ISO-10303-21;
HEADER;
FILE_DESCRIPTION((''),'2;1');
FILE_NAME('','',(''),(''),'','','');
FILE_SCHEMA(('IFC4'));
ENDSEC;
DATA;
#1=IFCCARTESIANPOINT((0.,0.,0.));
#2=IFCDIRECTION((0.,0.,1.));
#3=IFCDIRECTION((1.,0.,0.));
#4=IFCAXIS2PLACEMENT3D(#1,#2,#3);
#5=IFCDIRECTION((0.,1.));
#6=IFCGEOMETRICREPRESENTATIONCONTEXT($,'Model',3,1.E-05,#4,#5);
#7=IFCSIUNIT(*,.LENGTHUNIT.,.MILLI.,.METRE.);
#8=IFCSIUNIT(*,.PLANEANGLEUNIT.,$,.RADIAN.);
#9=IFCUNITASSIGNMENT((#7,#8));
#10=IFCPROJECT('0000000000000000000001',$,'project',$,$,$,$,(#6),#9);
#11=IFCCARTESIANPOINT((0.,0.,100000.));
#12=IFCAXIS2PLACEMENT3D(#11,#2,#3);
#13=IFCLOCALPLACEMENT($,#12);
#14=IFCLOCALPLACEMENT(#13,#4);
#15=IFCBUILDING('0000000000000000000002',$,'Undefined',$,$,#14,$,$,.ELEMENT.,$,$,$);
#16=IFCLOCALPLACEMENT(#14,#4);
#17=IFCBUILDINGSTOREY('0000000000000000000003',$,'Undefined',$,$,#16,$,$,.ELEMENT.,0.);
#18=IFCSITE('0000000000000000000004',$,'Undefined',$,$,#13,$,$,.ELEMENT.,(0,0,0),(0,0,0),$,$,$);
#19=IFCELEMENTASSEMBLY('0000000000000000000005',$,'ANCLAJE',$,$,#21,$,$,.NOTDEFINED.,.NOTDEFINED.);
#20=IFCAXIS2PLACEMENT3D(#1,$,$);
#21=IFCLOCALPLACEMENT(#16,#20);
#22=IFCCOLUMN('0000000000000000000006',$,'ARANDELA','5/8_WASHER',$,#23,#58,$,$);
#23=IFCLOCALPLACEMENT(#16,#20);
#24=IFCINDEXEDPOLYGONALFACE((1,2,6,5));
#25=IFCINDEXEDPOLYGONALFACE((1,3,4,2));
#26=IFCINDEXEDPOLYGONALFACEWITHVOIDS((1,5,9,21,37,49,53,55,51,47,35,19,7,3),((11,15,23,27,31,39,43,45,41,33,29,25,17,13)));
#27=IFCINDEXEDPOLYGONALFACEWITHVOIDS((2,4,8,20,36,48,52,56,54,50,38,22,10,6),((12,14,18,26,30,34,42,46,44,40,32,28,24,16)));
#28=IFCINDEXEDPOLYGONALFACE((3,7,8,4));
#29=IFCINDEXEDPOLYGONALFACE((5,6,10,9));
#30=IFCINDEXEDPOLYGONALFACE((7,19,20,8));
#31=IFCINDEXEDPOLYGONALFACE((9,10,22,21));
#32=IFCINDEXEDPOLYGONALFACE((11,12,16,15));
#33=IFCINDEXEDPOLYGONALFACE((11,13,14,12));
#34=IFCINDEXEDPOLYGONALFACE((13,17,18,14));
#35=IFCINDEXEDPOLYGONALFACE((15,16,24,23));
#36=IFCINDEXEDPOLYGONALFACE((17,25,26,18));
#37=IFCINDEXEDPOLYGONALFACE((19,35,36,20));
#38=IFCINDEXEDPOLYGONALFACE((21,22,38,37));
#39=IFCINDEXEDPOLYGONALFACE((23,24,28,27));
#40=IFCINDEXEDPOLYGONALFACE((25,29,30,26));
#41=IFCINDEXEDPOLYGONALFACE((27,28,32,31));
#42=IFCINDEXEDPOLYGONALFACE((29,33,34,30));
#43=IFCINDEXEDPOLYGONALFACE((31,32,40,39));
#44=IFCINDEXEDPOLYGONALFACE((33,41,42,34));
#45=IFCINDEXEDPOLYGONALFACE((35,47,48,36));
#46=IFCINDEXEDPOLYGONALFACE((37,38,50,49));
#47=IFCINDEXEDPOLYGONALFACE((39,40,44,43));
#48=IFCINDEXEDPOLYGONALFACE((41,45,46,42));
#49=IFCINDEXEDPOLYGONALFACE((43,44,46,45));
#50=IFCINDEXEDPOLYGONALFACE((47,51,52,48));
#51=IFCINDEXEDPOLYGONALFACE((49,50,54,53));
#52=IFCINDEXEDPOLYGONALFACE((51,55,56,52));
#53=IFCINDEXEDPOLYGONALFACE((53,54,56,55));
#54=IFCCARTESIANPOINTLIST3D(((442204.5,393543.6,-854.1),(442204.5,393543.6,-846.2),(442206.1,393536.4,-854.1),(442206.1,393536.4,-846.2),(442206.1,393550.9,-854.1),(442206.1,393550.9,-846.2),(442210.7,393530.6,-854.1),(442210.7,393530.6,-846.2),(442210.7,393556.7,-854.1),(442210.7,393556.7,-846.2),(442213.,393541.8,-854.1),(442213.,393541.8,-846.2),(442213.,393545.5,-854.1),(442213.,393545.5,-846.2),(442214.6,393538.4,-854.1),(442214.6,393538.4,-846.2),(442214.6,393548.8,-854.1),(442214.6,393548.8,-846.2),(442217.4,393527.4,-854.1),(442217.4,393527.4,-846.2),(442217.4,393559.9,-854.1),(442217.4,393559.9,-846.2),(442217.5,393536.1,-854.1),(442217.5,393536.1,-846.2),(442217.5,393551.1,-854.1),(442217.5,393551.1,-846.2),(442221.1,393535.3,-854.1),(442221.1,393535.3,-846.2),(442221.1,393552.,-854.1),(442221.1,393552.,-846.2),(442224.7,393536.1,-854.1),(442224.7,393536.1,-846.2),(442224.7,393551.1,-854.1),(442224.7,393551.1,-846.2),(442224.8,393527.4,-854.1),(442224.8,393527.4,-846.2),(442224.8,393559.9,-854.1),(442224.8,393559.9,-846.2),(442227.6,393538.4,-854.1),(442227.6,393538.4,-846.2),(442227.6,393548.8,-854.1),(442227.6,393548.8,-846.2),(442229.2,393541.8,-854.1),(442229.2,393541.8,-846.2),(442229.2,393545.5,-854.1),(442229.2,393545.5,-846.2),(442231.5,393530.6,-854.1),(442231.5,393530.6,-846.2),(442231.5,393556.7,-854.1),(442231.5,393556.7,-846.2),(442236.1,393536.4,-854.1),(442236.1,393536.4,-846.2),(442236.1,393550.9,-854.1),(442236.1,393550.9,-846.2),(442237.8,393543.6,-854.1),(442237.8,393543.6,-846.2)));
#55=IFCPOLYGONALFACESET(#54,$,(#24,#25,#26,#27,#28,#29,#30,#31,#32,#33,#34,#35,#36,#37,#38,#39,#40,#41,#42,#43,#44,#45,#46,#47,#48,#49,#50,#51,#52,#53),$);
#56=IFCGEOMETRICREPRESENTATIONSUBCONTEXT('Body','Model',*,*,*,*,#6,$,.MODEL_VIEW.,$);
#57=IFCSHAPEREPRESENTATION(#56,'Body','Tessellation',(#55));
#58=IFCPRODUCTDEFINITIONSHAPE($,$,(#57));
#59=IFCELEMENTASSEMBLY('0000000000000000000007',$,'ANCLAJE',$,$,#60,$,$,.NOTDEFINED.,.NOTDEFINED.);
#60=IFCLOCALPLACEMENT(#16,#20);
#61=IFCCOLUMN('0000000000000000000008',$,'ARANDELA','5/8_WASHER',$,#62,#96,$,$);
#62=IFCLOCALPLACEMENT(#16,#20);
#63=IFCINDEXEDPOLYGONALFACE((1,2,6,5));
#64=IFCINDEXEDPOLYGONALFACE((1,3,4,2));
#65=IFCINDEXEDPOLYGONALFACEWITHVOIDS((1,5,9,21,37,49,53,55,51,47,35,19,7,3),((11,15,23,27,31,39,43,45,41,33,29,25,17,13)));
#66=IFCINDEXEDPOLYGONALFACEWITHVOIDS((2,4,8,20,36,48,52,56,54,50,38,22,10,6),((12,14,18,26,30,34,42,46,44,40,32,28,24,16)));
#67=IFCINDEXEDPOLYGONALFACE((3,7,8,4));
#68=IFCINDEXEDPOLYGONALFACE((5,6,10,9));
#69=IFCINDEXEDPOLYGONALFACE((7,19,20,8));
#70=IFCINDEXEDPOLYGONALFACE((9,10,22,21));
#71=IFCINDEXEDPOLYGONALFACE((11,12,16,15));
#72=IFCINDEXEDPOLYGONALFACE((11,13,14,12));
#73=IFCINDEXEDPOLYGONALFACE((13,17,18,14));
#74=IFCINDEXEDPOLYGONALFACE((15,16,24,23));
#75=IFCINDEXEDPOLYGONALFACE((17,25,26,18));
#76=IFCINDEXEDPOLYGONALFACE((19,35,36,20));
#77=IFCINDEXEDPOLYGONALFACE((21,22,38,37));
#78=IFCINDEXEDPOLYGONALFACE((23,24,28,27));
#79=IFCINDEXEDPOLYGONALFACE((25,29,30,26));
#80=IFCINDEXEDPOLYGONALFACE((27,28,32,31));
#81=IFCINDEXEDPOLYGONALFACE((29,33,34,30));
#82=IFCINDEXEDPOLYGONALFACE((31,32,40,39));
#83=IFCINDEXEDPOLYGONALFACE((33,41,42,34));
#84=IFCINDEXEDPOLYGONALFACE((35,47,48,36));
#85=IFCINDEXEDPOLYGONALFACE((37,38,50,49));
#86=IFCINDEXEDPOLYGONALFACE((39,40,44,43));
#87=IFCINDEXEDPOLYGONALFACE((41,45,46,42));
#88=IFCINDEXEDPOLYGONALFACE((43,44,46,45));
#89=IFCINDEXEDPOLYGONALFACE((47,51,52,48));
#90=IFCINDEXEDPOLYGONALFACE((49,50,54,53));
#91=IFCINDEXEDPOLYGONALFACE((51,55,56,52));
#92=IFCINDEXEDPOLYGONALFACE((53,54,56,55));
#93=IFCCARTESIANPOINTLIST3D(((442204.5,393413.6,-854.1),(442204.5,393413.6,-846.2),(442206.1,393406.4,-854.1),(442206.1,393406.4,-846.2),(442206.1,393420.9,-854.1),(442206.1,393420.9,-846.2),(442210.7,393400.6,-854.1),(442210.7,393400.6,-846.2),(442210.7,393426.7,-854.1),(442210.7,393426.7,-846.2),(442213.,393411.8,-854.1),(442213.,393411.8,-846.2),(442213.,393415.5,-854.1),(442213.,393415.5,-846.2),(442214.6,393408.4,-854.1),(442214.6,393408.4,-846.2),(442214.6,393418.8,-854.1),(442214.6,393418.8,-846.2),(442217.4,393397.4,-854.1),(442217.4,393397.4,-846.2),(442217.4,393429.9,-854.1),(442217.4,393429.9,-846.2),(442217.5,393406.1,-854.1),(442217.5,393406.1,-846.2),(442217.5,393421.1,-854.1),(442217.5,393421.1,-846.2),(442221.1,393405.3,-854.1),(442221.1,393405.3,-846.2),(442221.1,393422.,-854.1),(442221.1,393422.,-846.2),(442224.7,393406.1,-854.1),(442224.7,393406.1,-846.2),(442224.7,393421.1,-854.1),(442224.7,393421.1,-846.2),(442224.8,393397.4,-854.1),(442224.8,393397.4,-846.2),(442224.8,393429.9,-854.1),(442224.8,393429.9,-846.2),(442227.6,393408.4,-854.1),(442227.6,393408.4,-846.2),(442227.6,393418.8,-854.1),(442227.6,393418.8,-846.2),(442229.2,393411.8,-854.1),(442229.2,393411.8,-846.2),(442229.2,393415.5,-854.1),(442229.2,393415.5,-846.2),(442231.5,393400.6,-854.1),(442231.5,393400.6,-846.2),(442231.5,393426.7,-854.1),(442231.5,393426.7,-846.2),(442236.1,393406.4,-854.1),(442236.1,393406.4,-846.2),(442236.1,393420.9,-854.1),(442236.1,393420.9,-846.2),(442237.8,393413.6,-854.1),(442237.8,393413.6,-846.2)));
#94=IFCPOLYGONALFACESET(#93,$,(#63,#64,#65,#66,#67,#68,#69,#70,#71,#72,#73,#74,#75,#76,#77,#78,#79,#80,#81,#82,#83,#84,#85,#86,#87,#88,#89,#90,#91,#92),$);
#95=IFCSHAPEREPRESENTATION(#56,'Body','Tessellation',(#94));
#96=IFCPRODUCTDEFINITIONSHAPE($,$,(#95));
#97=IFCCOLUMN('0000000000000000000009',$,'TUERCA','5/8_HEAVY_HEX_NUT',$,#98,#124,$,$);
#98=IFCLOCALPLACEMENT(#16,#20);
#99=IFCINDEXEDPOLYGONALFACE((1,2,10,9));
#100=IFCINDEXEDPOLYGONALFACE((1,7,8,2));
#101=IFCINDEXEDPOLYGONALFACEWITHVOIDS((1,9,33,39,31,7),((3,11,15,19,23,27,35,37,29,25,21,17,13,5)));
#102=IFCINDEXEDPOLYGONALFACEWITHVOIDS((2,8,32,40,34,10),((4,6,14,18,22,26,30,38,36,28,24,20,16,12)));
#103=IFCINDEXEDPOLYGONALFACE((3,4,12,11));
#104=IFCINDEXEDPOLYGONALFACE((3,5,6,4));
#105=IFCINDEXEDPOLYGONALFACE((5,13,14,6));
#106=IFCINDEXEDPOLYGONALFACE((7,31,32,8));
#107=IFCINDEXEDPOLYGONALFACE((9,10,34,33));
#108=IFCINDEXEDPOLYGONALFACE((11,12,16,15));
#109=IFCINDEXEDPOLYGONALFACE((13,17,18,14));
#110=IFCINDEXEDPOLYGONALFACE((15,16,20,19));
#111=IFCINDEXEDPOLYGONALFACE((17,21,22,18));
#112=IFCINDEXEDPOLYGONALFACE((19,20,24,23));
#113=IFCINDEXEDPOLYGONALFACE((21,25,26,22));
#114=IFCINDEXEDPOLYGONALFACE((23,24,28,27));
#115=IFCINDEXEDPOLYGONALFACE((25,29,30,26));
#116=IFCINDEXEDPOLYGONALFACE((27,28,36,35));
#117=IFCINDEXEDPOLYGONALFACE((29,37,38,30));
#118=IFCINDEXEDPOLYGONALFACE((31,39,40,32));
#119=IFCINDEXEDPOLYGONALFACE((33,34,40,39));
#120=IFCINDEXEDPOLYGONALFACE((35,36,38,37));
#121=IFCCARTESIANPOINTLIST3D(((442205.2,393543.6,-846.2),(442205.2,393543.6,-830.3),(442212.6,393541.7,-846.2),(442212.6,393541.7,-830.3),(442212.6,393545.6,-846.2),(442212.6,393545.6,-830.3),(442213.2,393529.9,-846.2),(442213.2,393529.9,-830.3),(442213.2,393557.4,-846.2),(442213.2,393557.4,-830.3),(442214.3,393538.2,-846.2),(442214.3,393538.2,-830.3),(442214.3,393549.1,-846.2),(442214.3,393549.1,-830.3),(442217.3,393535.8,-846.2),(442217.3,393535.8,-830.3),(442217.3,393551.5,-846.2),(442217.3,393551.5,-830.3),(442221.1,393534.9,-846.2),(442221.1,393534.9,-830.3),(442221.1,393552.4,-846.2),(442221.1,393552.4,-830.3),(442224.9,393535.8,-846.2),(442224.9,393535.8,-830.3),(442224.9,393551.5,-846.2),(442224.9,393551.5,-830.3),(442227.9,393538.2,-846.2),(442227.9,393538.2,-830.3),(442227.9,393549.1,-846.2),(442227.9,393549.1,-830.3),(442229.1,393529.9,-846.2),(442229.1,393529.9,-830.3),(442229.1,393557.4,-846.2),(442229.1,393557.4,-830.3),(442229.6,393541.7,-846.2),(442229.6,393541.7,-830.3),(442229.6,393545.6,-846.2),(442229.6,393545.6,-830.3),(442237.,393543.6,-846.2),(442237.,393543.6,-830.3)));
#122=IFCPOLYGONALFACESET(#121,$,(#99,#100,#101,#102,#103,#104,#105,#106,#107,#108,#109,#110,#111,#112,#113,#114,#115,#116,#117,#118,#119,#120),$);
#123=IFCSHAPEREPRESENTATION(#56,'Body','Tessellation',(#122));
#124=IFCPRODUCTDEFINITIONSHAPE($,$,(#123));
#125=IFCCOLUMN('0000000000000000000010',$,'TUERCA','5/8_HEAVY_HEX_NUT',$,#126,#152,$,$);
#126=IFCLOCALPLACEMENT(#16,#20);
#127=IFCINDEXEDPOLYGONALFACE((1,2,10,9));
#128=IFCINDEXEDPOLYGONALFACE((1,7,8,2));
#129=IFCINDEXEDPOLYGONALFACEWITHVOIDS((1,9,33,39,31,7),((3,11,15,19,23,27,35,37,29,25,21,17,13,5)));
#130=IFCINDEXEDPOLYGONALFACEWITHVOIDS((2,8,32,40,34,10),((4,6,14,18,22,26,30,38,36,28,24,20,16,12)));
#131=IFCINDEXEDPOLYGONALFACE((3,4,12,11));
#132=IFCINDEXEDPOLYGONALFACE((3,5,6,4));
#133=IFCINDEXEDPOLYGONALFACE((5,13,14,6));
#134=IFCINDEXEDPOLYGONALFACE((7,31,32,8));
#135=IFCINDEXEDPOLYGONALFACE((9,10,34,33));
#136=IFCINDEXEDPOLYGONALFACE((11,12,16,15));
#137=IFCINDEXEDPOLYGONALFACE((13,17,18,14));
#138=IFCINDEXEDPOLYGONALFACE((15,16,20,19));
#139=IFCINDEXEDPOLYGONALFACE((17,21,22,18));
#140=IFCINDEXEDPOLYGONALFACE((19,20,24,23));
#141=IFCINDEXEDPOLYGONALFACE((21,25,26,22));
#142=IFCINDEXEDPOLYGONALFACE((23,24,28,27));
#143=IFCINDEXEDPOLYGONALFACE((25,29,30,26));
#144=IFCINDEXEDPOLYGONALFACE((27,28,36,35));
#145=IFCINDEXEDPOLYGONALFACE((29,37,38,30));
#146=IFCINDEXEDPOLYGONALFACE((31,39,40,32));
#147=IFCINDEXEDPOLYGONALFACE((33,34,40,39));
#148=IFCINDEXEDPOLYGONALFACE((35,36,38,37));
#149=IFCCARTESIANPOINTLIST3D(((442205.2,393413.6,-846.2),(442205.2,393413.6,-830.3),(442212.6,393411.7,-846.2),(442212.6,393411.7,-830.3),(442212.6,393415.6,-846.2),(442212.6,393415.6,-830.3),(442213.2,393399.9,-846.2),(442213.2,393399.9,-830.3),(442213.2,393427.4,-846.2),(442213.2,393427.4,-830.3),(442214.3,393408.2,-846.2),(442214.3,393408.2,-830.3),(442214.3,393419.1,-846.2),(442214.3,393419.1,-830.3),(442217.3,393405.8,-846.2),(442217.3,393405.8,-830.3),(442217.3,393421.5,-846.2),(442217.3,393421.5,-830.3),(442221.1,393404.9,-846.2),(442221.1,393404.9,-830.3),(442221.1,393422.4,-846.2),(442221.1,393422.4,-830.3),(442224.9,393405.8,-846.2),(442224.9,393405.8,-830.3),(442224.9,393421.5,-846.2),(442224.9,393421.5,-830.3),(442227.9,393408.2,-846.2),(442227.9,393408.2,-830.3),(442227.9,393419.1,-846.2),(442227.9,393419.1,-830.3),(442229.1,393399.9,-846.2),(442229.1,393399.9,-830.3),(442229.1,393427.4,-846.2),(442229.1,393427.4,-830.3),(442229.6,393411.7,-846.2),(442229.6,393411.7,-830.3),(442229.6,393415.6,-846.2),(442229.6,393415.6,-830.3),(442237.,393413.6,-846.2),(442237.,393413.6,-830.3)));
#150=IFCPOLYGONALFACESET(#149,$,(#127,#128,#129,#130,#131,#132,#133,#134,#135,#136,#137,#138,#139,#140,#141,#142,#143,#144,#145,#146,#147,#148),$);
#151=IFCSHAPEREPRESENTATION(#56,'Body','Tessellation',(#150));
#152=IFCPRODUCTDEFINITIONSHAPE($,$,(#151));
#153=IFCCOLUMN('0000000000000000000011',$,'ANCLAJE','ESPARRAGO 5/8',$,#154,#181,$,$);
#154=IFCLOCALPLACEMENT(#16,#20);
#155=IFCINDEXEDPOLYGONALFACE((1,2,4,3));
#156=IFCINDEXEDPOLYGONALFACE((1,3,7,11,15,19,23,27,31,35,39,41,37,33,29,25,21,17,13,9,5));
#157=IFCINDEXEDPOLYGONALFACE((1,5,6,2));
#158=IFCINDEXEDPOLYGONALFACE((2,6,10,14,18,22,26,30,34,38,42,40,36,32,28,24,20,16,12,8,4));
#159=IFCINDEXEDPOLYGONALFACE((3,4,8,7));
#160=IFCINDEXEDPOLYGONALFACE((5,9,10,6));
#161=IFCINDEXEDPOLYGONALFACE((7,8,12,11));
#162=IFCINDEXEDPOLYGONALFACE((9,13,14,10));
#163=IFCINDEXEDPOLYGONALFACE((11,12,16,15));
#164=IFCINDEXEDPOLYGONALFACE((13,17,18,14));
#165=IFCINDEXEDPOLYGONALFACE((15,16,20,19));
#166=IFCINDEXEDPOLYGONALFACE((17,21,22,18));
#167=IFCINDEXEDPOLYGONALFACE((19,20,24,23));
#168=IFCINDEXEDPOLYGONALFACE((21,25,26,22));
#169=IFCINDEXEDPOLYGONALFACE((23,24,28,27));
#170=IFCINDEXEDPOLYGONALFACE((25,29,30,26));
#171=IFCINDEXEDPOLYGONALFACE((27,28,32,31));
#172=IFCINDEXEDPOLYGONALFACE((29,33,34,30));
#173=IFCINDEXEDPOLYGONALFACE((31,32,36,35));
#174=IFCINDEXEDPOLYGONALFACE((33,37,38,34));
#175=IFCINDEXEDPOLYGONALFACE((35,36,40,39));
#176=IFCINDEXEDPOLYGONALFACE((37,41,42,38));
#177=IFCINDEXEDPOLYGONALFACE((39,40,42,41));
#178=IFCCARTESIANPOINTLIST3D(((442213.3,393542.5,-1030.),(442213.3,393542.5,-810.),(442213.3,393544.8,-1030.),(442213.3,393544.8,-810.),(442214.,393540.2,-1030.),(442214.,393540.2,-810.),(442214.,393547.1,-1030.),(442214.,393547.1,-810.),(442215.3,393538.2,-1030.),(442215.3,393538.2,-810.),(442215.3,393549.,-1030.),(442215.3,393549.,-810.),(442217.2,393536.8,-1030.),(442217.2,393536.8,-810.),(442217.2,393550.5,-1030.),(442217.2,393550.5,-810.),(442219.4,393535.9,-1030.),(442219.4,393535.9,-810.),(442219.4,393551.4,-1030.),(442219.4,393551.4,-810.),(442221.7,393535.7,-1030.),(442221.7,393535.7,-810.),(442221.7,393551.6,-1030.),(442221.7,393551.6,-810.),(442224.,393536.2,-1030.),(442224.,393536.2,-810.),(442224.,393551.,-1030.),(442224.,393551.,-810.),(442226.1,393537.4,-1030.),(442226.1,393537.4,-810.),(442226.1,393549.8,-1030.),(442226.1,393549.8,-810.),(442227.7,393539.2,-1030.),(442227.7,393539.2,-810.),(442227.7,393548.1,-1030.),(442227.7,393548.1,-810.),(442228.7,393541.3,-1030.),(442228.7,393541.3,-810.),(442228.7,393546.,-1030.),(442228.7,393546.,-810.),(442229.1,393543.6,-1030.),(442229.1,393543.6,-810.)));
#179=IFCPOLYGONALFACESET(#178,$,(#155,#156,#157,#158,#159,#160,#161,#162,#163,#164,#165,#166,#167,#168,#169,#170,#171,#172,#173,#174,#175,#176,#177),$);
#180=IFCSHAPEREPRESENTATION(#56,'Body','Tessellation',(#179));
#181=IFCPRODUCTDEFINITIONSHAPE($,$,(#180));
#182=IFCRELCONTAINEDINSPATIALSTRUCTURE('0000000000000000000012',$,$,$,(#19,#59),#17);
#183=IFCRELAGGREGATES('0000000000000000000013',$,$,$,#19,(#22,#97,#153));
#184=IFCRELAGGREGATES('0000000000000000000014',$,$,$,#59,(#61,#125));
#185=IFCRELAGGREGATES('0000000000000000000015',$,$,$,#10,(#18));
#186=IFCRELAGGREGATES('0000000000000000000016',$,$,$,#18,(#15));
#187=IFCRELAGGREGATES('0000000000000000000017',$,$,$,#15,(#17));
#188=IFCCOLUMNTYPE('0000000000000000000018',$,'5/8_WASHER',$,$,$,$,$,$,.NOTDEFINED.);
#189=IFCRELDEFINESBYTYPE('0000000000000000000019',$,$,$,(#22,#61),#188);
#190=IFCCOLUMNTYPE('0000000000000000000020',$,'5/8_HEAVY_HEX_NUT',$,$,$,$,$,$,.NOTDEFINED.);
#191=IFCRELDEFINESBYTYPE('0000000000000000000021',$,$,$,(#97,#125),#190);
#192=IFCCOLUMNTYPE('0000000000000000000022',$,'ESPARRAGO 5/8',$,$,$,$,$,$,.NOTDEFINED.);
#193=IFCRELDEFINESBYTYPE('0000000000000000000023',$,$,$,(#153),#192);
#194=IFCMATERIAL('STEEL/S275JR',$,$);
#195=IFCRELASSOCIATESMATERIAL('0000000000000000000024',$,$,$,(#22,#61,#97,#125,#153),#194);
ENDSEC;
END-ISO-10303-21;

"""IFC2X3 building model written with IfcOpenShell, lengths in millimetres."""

from ifc_helpers import new_model, si_unit, direction, frame, origin_with_axes, origin_2d_with_axis, place, context, subcontext, project, spatial, polyline, circle, outline, extrude, material, type_object, element, aggregate, save


model = new_model("IFC2X3")

# Units and contexts
model_context = context("Model", 3, precision=1e-05, world=origin_with_axes(), true_north=direction((0.0, 1.0)))
body_context = subcontext(model_context, "Body", "Model", "MODEL_VIEW")
ifc_project = project(units=[si_unit("LENGTHUNIT", "METRE", prefix="MILLI"), si_unit("PLANEANGLEUNIT", "RADIAN")], contexts=[model_context])

# Site, building, storey
site_placement = place(None, frame((0.0, 0.0, 100000.0), z_axis=(0.0, 0.0, 1.0), x_axis=(1.0, 0.0, 0.0)))
site = spatial("IfcSite", under=ifc_project, at=site_placement, Name="Undefined", CompositionType="ELEMENT", RefLatitude=(0, 0, 0), RefLongitude=(0, 0, 0))
building_placement = place(site_placement, origin_with_axes())
building = spatial("IfcBuilding", under=site, at=building_placement, Name="Undefined", CompositionType="ELEMENT")
storey_placement = place(building_placement, origin_with_axes())
storey = spatial("IfcBuildingStorey", under=building, at=storey_placement, Name="Undefined", CompositionType="ELEMENT", Elevation=0.0)

# Element assemblies, columns
assembly_1_placement = place(storey_placement, origin_with_axes())
assembly_1 = element("IfcElementAssembly", 1, at=assembly_1_placement, inside=storey, Name="ANCLAJE", AssemblyPlace="NOTDEFINED", PredefinedType="NOTDEFINED")
ifc_material_1 = material(Name="STEEL/S275JR")
column_type_1 = type_object("IfcColumnType", Name="5/8_WASHER", PredefinedType="NOTDEFINED")
column_1_placement = place(assembly_1_placement, frame((442221.1, 393543.6, -846.2), z_axis=(0.0, 0.0, -1.0), x_axis=(0.0, 1.0, 0.0)))
column_1 = element("IfcColumn", 2, at=column_1_placement, type_object=column_type_1, material=ifc_material_1, Name="ARANDELA", Description="5/8_WASHER", context=body_context, shape_type="SweptSolid", body=[
    extrude(outline(polyline([(10.4, 13.0), (15.0, 7.2), (16.7, 0.0), (15.0, -7.2), (10.4, -13.0), (3.7, -16.3), (-3.7, -16.3), (-10.4, -13.0), (-15.0, -7.2), (-16.7, 0.0), (-15.0, 7.2), (-10.4, 13.0), (-3.7, 16.3), (3.7, 16.3), (10.4, 13.0)]), holes=[polyline([(6.5, -5.2), (8.1, -1.9), (8.1, 1.9), (6.5, 5.2), (3.6, 7.5), (0.0, 8.3), (-3.6, 7.5), (-6.5, 5.2), (-8.1, 1.9), (-8.1, -1.9), (-6.5, -5.2), (-3.6, -7.5), (0.0, -8.3), (3.6, -7.5), (6.5, -5.2)])]), frame((0.0, 0.0, 7.9), z_axis=(0.0, 0.0, -1.0), x_axis=(0.0, 1.0, 0.0)), (0.0, 0.0, 1.0), 7.9),
])
assembly_2_placement = place(storey_placement, origin_with_axes())
assembly_2 = element("IfcElementAssembly", 3, at=assembly_2_placement, inside=storey, Name="ANCLAJE", AssemblyPlace="NOTDEFINED", PredefinedType="NOTDEFINED")
column_2_placement = place(assembly_2_placement, frame((442221.1, 393413.6, -846.2), z_axis=(0.0, 0.0, -1.0), x_axis=(0.0, 1.0, 0.0)))
column_2 = element("IfcColumn", 4, at=column_2_placement, type_object=column_type_1, material=ifc_material_1, Name="ARANDELA", Description="5/8_WASHER", context=body_context, shape_type="SweptSolid", body=[
    extrude(outline(polyline([(10.4, 13.0), (15.0, 7.2), (16.7, 0.0), (15.0, -7.2), (10.4, -13.0), (3.7, -16.3), (-3.7, -16.3), (-10.4, -13.0), (-15.0, -7.2), (-16.7, 0.0), (-15.0, 7.2), (-10.4, 13.0), (-3.7, 16.3), (3.7, 16.3), (10.4, 13.0)]), holes=[polyline([(6.5, -5.2), (8.1, -1.9), (8.1, 1.9), (6.5, 5.2), (3.6, 7.5), (0.0, 8.3), (-3.6, 7.5), (-6.5, 5.2), (-8.1, 1.9), (-8.1, -1.9), (-6.5, -5.2), (-3.6, -7.5), (0.0, -8.3), (3.6, -7.5), (6.5, -5.2)])]), frame((0.0, 0.0, 7.9), z_axis=(0.0, 0.0, -1.0), x_axis=(0.0, 1.0, 0.0)), (0.0, 0.0, 1.0), 7.9),
])

# Columns
column_type_2 = type_object("IfcColumnType", Name="5/8_HEAVY_HEX_NUT", PredefinedType="NOTDEFINED")
column_3_placement = place(assembly_1_placement, frame((442221.1, 393543.6, -830.3), z_axis=(0.0, 0.0, -1.0), x_axis=(0.0, 1.0, 0.0)))
column_3 = element("IfcColumn", 5, at=column_3_placement, type_object=column_type_2, material=ifc_material_1, Name="TUERCA", Description="5/8_HEAVY_HEX_NUT", context=body_context, shape_type="SweptSolid", body=[
    extrude(outline(polyline([(-7.9, -13.7), (-15.9, 0.0), (-7.9, 13.7), (7.9, 13.7), (15.9, 0.0), (7.9, -13.7), (-7.9, -13.7)]), holes=[polyline([(3.8, 7.9), (0.0, 8.7), (-3.8, 7.9), (-6.8, 5.4), (-8.5, 1.9), (-8.5, -1.9), (-6.8, -5.4), (-3.8, -7.9), (0.0, -8.7), (3.8, -7.9), (6.8, -5.4), (8.5, -1.9), (8.5, 1.9), (6.8, 5.4), (3.8, 7.9)])]), frame((0.0, 0.0, 15.9), z_axis=(0.0, 0.0, -1.0), x_axis=(0.0, 1.0, 0.0)), (0.0, 0.0, 1.0), 15.9),
])
column_4_placement = place(assembly_2_placement, frame((442221.1, 393413.6, -830.3), z_axis=(0.0, 0.0, -1.0), x_axis=(0.0, 1.0, 0.0)))
column_4 = element("IfcColumn", 6, at=column_4_placement, type_object=column_type_2, material=ifc_material_1, Name="TUERCA", Description="5/8_HEAVY_HEX_NUT", context=body_context, shape_type="SweptSolid", body=[
    extrude(outline(polyline([(-7.9, -13.7), (-15.9, 0.0), (-7.9, 13.7), (7.9, 13.7), (15.9, 0.0), (7.9, -13.7), (-7.9, -13.7)]), holes=[polyline([(3.8, 7.9), (0.0, 8.7), (-3.8, 7.9), (-6.8, 5.4), (-8.5, 1.9), (-8.5, -1.9), (-6.8, -5.4), (-3.8, -7.9), (0.0, -8.7), (3.8, -7.9), (6.8, -5.4), (8.5, -1.9), (8.5, 1.9), (6.8, 5.4), (3.8, 7.9)])]), frame((0.0, 0.0, 15.9), z_axis=(0.0, 0.0, -1.0), x_axis=(0.0, 1.0, 0.0)), (0.0, 0.0, 1.0), 15.9),
])
column_type_3 = type_object("IfcColumnType", Name="ESPARRAGO 5/8", PredefinedType="NOTDEFINED")
column_5_placement = place(assembly_1_placement, frame((442221.1, 393543.6, -810.0), z_axis=(0.0, 0.0, -1.0), x_axis=(0.0, 1.0, 0.0)))
column_5 = element("IfcColumn", 7, at=column_5_placement, type_object=column_type_3, material=ifc_material_1, Name="ANCLAJE", Description="ESPARRAGO 5/8", context=body_context, shape_type="SweptSolid", body=[
    extrude(circle(Radius=7.9, at=origin_2d_with_axis()), frame((0.0, 0.0, 220.0), z_axis=(0.0, 0.0, -1.0), x_axis=(0.0, 1.0, 0.0)), (0.0, 0.0, 1.0), 220.0),
])
aggregate(assembly_1, [column_1, column_3, column_5])
aggregate(assembly_2, [column_2, column_4])

save(model, "model.ifc")
